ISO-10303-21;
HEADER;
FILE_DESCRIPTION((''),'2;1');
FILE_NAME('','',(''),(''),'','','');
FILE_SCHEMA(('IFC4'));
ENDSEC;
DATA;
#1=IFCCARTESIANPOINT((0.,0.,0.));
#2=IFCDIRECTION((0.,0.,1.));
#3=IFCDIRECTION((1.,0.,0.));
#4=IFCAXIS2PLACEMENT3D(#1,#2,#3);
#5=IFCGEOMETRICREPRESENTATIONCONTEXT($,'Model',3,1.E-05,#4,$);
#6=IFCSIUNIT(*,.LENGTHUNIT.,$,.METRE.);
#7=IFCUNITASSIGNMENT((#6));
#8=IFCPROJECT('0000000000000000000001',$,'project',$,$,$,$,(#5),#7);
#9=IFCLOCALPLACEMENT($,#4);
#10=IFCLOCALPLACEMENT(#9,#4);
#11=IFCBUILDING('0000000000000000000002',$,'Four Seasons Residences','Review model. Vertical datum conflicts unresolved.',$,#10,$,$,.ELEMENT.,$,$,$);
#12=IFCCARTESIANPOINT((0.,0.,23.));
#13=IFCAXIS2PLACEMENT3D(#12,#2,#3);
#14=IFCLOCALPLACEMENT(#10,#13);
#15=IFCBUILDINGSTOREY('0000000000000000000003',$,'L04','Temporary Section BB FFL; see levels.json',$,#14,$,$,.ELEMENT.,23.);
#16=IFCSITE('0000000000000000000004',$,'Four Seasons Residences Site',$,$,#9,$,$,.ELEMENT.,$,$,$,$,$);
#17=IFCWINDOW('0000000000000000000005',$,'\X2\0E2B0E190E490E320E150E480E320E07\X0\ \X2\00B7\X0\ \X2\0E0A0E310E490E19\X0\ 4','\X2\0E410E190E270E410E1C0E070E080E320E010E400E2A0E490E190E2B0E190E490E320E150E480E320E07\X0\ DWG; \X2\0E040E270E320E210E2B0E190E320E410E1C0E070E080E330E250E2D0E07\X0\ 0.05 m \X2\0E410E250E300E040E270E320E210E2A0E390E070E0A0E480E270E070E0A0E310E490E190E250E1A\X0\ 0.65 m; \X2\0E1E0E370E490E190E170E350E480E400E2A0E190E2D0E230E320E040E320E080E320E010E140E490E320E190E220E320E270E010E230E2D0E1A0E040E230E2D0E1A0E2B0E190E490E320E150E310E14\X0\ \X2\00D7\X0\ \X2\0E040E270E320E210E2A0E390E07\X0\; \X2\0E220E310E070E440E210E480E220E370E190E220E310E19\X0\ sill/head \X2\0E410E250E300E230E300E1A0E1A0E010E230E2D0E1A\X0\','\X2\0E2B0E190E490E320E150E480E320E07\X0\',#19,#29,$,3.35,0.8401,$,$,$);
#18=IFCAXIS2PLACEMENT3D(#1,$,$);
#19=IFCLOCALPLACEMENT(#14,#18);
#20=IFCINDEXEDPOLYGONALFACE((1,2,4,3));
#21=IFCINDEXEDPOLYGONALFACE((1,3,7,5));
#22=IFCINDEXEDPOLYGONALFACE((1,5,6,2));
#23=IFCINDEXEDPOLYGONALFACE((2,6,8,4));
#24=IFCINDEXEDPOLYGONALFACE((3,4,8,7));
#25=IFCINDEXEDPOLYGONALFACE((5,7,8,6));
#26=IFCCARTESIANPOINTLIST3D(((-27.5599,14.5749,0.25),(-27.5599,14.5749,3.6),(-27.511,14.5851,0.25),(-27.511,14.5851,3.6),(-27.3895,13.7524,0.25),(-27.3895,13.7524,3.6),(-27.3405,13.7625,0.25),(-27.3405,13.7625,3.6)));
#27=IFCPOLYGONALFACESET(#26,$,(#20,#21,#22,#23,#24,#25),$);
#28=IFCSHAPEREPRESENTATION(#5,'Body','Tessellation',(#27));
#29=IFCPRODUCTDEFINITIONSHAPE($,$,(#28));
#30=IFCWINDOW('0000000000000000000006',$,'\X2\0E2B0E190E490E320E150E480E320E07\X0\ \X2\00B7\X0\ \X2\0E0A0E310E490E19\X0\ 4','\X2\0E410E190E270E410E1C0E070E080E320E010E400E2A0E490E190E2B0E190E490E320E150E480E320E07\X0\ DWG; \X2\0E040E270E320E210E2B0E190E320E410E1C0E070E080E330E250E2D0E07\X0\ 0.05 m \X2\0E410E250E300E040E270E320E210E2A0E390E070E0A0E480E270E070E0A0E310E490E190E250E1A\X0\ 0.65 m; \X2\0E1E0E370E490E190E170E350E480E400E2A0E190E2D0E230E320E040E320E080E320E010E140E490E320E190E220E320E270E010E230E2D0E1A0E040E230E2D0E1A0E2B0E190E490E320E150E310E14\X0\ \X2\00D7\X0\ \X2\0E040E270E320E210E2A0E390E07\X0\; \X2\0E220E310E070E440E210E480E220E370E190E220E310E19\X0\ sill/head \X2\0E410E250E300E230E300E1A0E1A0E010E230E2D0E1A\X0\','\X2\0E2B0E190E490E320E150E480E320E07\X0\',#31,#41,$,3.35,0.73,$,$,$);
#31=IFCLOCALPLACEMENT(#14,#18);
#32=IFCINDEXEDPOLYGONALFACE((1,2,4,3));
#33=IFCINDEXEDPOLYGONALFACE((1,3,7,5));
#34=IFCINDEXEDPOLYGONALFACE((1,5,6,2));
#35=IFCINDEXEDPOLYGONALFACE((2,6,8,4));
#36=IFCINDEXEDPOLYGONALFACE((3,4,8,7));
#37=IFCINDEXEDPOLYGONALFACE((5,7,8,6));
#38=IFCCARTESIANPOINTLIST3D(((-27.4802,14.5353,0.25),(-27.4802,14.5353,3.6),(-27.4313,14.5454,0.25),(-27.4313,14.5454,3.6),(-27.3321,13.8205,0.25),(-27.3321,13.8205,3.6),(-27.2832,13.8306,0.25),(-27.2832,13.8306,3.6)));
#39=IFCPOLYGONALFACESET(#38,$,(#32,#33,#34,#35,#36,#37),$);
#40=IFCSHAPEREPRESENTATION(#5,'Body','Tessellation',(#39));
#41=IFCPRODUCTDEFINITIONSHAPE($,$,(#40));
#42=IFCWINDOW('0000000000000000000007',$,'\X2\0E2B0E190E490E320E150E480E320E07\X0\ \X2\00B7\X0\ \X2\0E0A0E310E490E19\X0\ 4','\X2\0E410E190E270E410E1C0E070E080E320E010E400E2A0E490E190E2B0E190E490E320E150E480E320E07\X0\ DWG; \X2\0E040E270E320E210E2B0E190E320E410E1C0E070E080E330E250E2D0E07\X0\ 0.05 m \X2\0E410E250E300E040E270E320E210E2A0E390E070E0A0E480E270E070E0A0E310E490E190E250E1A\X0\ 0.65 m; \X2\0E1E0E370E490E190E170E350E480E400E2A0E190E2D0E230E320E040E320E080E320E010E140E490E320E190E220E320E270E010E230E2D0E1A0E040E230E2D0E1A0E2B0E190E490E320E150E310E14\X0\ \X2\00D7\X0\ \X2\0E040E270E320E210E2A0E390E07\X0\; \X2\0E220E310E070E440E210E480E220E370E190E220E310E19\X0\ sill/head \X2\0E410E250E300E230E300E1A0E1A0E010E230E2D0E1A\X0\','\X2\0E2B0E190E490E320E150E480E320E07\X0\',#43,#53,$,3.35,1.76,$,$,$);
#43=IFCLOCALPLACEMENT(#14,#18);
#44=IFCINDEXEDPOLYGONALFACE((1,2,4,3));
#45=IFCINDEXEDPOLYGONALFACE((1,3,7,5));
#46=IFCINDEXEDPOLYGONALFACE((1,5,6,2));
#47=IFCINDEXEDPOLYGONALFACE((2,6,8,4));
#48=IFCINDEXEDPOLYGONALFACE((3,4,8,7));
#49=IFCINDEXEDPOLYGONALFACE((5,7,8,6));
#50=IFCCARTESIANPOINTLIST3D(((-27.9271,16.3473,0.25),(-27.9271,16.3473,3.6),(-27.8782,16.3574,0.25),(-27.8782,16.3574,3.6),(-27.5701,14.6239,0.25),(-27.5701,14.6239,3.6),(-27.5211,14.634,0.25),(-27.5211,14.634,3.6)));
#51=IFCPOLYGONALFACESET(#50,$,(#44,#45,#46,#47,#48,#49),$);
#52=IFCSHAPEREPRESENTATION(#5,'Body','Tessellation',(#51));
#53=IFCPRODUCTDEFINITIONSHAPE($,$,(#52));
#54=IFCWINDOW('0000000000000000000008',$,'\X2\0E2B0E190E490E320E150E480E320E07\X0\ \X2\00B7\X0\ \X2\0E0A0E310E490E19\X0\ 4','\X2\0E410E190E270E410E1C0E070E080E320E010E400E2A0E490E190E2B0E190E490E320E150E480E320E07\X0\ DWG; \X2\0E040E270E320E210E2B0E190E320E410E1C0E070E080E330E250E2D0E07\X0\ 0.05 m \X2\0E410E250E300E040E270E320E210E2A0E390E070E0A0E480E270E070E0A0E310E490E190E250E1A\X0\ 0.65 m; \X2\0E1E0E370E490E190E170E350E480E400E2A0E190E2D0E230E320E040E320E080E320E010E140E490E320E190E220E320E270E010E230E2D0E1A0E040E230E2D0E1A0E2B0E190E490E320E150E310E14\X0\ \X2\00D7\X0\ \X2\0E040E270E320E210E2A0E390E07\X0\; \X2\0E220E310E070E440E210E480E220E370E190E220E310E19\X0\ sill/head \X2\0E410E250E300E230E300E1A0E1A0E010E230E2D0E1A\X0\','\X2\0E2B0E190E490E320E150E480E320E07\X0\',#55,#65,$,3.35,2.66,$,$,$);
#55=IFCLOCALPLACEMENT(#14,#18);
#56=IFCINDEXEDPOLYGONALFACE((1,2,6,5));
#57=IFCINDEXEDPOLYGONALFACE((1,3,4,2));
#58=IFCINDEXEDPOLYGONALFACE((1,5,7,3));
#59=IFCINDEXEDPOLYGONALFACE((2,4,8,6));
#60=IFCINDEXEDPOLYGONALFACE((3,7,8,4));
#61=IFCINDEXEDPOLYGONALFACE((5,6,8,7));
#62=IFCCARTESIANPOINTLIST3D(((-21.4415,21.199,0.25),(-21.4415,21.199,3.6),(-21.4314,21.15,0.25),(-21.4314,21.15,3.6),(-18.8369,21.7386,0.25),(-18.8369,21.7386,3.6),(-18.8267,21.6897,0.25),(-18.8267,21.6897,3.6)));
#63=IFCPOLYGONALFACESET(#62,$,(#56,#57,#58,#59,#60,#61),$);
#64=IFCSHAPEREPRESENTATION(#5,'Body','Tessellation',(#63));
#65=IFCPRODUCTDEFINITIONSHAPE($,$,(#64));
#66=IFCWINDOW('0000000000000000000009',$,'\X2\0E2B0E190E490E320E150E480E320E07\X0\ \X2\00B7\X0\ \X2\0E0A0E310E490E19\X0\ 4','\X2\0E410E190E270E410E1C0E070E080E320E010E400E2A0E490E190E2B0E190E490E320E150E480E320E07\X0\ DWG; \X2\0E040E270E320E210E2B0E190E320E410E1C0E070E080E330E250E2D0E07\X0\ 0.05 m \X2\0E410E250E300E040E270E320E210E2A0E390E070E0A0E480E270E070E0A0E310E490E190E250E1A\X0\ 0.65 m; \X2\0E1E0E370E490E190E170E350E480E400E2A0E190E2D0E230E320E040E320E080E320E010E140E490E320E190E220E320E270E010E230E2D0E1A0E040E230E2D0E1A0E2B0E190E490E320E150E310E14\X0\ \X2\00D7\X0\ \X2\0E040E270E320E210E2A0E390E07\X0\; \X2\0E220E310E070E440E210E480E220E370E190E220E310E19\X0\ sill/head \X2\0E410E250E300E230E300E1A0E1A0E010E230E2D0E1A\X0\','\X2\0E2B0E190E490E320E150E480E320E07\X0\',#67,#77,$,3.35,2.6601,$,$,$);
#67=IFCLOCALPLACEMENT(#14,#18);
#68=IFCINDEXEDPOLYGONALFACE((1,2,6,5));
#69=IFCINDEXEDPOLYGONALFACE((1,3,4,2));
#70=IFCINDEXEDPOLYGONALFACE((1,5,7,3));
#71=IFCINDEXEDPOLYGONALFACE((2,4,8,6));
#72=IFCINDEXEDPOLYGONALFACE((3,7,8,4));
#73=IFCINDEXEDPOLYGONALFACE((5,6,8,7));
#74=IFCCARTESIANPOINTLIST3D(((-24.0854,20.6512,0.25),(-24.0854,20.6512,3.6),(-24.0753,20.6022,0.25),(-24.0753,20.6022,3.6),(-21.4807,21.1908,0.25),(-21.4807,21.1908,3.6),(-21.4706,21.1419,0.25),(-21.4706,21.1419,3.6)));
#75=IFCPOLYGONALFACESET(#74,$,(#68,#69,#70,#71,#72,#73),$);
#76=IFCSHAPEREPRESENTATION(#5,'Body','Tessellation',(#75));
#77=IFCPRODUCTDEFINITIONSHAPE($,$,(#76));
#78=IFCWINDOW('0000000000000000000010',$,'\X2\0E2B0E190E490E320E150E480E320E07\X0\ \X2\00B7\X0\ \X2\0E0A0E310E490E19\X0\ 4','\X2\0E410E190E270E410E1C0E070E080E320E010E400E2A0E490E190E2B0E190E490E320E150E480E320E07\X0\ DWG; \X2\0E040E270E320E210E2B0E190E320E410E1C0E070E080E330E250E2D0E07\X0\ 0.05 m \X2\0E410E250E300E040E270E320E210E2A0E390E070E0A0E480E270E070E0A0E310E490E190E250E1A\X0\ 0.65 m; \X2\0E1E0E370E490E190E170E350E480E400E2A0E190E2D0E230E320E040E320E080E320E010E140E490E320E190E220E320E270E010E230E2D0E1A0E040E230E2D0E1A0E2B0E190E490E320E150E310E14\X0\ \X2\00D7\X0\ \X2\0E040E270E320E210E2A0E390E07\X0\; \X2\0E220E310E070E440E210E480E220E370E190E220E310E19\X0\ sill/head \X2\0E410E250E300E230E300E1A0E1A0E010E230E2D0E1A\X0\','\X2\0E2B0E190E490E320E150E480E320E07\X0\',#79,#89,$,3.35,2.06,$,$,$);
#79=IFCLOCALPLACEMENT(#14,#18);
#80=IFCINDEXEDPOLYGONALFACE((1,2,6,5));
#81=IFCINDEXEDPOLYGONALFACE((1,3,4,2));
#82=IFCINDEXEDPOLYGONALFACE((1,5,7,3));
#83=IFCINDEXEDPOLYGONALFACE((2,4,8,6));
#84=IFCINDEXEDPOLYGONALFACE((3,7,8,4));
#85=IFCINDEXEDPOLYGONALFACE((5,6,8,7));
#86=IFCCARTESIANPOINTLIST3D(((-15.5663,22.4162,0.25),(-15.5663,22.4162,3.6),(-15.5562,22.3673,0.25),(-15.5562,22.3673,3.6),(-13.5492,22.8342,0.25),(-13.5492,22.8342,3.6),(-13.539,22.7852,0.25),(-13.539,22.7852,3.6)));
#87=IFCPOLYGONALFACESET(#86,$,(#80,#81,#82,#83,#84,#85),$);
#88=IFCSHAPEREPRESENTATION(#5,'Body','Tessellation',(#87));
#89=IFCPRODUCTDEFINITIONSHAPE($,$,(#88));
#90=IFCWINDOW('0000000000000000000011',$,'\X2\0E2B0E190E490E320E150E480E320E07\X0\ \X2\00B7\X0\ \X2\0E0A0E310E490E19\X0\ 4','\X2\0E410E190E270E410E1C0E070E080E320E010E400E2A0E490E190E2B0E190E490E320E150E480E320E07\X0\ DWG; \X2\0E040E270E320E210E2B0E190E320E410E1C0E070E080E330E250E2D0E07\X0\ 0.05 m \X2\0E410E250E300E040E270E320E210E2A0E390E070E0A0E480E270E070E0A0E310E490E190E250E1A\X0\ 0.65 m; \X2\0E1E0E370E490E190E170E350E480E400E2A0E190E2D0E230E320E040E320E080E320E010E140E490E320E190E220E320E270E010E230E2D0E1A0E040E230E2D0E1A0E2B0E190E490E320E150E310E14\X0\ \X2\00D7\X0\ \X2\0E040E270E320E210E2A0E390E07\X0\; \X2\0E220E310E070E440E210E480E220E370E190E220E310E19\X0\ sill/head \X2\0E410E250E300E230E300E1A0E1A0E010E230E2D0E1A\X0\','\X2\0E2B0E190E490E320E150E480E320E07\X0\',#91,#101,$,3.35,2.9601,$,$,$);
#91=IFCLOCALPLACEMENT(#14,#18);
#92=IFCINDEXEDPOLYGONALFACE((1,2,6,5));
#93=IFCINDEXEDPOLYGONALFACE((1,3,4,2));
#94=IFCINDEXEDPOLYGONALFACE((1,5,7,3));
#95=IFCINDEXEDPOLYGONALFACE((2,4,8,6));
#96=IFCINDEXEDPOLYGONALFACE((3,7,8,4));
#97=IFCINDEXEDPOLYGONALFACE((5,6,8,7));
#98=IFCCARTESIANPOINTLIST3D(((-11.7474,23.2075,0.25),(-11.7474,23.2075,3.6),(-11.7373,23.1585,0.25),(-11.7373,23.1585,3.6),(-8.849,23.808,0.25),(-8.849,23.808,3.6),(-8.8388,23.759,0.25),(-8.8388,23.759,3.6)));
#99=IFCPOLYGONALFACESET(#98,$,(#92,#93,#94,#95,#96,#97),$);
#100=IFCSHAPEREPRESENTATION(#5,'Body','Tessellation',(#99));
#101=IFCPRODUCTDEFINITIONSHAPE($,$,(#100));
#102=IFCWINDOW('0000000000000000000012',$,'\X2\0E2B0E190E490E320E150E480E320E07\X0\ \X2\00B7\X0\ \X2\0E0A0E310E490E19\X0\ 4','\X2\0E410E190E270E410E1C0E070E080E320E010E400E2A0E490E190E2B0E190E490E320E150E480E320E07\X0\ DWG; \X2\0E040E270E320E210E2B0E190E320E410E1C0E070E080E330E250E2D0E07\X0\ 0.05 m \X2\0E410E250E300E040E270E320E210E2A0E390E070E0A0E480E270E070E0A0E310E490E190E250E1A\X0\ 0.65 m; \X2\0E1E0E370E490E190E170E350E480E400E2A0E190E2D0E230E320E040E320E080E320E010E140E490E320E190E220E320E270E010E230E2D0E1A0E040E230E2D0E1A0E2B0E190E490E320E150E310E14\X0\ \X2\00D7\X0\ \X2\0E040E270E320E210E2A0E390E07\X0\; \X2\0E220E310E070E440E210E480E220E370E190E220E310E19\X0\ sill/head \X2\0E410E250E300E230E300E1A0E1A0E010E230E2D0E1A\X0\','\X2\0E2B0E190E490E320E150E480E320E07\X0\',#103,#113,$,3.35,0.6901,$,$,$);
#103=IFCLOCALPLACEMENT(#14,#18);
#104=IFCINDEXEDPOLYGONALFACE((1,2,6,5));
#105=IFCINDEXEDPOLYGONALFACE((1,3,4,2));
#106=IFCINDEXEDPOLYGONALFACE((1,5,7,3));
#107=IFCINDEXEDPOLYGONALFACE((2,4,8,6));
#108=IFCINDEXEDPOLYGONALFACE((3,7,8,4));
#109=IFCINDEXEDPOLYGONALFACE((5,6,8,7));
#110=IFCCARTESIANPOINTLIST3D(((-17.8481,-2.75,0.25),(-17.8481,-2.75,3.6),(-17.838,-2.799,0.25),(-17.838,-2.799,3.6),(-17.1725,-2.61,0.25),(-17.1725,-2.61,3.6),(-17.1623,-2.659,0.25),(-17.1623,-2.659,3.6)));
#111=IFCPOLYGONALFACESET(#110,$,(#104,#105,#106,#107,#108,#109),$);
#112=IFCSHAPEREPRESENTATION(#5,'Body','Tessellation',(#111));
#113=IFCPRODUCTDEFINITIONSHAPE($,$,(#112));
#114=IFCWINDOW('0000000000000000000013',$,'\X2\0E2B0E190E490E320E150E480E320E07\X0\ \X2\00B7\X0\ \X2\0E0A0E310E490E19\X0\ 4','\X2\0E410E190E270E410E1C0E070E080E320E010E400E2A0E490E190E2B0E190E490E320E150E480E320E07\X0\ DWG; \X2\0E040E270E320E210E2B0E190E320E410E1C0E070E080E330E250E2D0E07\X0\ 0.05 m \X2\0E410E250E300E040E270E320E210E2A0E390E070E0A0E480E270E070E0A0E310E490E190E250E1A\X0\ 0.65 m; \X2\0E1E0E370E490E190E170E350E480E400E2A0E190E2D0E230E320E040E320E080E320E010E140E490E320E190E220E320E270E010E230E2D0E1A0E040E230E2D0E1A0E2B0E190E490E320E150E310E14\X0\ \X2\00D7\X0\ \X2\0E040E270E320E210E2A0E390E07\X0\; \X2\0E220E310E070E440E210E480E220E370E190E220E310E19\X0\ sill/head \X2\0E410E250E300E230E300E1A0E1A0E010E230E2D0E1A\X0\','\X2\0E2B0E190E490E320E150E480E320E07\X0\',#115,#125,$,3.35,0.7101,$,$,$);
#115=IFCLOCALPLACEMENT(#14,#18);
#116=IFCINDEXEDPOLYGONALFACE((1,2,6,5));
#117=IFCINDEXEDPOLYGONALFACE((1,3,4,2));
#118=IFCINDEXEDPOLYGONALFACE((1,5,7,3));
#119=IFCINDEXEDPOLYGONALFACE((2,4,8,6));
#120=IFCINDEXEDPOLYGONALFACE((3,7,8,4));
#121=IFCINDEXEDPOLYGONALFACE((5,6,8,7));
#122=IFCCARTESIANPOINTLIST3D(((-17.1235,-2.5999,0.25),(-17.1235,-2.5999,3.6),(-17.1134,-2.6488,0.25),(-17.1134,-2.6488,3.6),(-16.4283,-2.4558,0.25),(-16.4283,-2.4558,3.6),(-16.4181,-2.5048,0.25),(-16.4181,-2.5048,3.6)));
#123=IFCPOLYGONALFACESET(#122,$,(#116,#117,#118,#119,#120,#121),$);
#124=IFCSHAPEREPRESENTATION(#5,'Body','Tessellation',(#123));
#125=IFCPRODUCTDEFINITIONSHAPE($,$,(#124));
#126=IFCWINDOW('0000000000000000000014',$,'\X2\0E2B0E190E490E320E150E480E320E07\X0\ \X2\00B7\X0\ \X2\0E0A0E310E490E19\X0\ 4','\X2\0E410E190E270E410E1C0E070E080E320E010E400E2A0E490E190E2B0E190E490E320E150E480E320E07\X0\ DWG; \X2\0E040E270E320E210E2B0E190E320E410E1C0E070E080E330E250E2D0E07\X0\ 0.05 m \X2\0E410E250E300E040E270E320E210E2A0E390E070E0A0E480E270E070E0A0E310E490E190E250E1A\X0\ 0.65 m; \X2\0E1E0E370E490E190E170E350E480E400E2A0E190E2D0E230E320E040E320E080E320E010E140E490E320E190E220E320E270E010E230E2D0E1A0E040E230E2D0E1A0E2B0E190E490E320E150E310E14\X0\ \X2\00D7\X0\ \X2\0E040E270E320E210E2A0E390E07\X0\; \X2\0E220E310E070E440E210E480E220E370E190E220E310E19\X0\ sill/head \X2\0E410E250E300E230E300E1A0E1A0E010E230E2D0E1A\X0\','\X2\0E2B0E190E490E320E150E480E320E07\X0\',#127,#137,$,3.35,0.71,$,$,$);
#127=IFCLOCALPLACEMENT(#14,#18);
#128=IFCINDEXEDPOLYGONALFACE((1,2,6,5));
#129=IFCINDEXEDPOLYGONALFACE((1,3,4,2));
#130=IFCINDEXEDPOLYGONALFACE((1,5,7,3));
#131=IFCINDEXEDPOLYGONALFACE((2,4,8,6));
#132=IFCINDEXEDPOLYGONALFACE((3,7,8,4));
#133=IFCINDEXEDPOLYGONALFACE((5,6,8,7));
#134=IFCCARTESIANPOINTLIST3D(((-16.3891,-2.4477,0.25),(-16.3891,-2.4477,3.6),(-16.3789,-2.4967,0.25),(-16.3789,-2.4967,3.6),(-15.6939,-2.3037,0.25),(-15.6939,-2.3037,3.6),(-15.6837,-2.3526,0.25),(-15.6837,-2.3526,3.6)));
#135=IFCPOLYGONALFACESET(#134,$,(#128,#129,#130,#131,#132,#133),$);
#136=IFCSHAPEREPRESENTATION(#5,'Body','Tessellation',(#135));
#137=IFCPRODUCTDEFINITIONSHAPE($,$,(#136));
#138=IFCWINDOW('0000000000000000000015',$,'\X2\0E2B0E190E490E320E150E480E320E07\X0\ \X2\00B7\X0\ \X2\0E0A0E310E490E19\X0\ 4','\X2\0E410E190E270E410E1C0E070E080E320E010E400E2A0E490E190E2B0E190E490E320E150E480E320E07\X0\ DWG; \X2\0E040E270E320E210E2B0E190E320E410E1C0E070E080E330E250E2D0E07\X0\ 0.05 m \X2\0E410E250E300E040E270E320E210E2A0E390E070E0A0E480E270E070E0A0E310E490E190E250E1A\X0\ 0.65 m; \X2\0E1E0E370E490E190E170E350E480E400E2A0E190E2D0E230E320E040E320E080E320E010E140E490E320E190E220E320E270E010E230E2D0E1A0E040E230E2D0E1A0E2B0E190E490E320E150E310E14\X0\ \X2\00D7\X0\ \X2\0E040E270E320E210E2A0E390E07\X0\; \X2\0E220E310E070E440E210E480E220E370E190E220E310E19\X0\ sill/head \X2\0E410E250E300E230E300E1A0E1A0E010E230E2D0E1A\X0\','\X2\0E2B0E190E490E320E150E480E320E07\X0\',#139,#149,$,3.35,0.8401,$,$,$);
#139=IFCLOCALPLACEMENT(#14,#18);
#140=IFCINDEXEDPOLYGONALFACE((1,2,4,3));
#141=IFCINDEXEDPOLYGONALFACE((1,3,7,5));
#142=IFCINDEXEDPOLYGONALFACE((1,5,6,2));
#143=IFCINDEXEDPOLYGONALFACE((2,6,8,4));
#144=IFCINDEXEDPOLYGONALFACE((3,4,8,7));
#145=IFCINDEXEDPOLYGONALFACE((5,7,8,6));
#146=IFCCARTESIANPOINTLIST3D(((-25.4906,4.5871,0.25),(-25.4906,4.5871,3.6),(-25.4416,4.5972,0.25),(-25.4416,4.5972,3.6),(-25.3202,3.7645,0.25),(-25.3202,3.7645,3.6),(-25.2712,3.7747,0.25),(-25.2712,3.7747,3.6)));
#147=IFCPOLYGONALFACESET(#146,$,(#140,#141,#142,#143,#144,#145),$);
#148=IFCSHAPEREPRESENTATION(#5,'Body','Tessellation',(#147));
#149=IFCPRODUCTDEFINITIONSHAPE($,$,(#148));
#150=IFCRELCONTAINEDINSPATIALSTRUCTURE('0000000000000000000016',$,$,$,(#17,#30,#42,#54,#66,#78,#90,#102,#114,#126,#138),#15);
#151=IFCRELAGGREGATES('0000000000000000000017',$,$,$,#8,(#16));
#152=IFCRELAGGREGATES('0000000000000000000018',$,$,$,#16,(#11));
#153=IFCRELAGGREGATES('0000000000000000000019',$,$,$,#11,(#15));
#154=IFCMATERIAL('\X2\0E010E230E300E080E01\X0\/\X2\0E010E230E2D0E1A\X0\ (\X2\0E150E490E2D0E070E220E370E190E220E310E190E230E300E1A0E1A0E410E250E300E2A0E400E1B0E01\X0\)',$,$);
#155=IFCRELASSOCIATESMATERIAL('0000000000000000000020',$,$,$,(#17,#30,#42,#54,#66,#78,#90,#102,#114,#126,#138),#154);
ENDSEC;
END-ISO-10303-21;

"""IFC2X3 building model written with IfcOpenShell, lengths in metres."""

from ifc_helpers import new_model, si_unit, frame, origin_with_axes, place, context, project, spatial, polyline, outline, extrude, material, element, save


model = new_model("IFC2X3")

# Units and contexts
model_context = context("Model", 3, precision=1e-05, world=origin_with_axes())
ifc_project = project(units=[si_unit("LENGTHUNIT", "METRE")], contexts=[model_context])

# Site, building, storey
site_placement = place(None, origin_with_axes())
site = spatial("IfcSite", under=ifc_project, at=site_placement, Name="Four Seasons Residences Site", CompositionType="ELEMENT")
building_placement = place(site_placement, origin_with_axes())
building = spatial("IfcBuilding", under=site, at=building_placement, Name="Four Seasons Residences", Description="Review model. Vertical datum conflicts unresolved.", CompositionType="ELEMENT")
storey_placement = place(building_placement, frame((0.0, 0.0, 23.0), z_axis=(0.0, 0.0, 1.0), x_axis=(1.0, 0.0, 0.0)))
storey = spatial("IfcBuildingStorey", under=building, at=storey_placement, Name="L04", Description="Temporary Section BB FFL; see levels.json", CompositionType="ELEMENT", Elevation=23.0)

# Windows
ifc_material = material(Name="กระจก/กรอบ (ต้องยืนยันระบบและสเปก)")
window_1_placement = place(storey_placement, origin_with_axes())
element("IfcWindow", 1, at=window_1_placement, inside=storey, material=ifc_material, Name="หน้าต่าง · ชั้น 4", Description="แนวแผงจากเส้นหน้าต่าง DWG; ความหนาแผงจำลอง 0.05 m และความสูงช่วงชั้นลบ 0.65 m; พื้นที่เสนอราคาจากด้านยาวกรอบครอบหน้าตัด × ความสูง; ยังไม่ยืนยัน sill/head และระบบกรอบ", ObjectType="หน้าต่าง", OverallHeight=3.35, OverallWidth=0.8401, context=model_context, shape_type="SweptSolid", body=[
    extrude(outline(polyline([(-27.3405, 13.7625), (-27.3895, 13.7524), (-27.5599, 14.5749), (-27.511, 14.5851), (-27.3405, 13.7625)])), frame((0.0, 0.0, 0.25), z_axis=(0.0, 0.0, 1.0), x_axis=(1.0, 0.0, 0.0)), (0.0, 0.0, 1.0), 3.35),
])
window_2_placement = place(storey_placement, origin_with_axes())
element("IfcWindow", 2, at=window_2_placement, inside=storey, material=ifc_material, Name="หน้าต่าง · ชั้น 4", Description="แนวแผงจากเส้นหน้าต่าง DWG; ความหนาแผงจำลอง 0.05 m และความสูงช่วงชั้นลบ 0.65 m; พื้นที่เสนอราคาจากด้านยาวกรอบครอบหน้าตัด × ความสูง; ยังไม่ยืนยัน sill/head และระบบกรอบ", ObjectType="หน้าต่าง", OverallHeight=3.35, OverallWidth=0.73, context=model_context, shape_type="SweptSolid", body=[
    extrude(outline(polyline([(-27.2832, 13.8306), (-27.3321, 13.8205), (-27.4802, 14.5353), (-27.4313, 14.5454), (-27.2832, 13.8306)])), frame((0.0, 0.0, 0.25), z_axis=(0.0, 0.0, 1.0), x_axis=(1.0, 0.0, 0.0)), (0.0, 0.0, 1.0), 3.35),
])
window_3_placement = place(storey_placement, origin_with_axes())
element("IfcWindow", 3, at=window_3_placement, inside=storey, material=ifc_material, Name="หน้าต่าง · ชั้น 4", Description="แนวแผงจากเส้นหน้าต่าง DWG; ความหนาแผงจำลอง 0.05 m และความสูงช่วงชั้นลบ 0.65 m; พื้นที่เสนอราคาจากด้านยาวกรอบครอบหน้าตัด × ความสูง; ยังไม่ยืนยัน sill/head และระบบกรอบ", ObjectType="หน้าต่าง", OverallHeight=3.35, OverallWidth=1.76, context=model_context, shape_type="SweptSolid", body=[
    extrude(outline(polyline([(-27.5211, 14.634), (-27.5701, 14.6239), (-27.9271, 16.3473), (-27.8782, 16.3574), (-27.5211, 14.634)])), frame((0.0, 0.0, 0.25), z_axis=(0.0, 0.0, 1.0), x_axis=(1.0, 0.0, 0.0)), (0.0, 0.0, 1.0), 3.35),
])
window_4_placement = place(storey_placement, origin_with_axes())
element("IfcWindow", 4, at=window_4_placement, inside=storey, material=ifc_material, Name="หน้าต่าง · ชั้น 4", Description="แนวแผงจากเส้นหน้าต่าง DWG; ความหนาแผงจำลอง 0.05 m และความสูงช่วงชั้นลบ 0.65 m; พื้นที่เสนอราคาจากด้านยาวกรอบครอบหน้าตัด × ความสูง; ยังไม่ยืนยัน sill/head และระบบกรอบ", ObjectType="หน้าต่าง", OverallHeight=3.35, OverallWidth=2.66, context=model_context, shape_type="SweptSolid", body=[
    extrude(outline(polyline([(-18.8369, 21.7386), (-18.8267, 21.6897), (-21.4314, 21.15), (-21.4415, 21.199), (-18.8369, 21.7386)])), frame((0.0, 0.0, 0.25), z_axis=(0.0, 0.0, 1.0), x_axis=(1.0, 0.0, 0.0)), (0.0, 0.0, 1.0), 3.35),
])
window_5_placement = place(storey_placement, origin_with_axes())
element("IfcWindow", 5, at=window_5_placement, inside=storey, material=ifc_material, Name="หน้าต่าง · ชั้น 4", Description="แนวแผงจากเส้นหน้าต่าง DWG; ความหนาแผงจำลอง 0.05 m และความสูงช่วงชั้นลบ 0.65 m; พื้นที่เสนอราคาจากด้านยาวกรอบครอบหน้าตัด × ความสูง; ยังไม่ยืนยัน sill/head และระบบกรอบ", ObjectType="หน้าต่าง", OverallHeight=3.35, OverallWidth=2.6601, context=model_context, shape_type="SweptSolid", body=[
    extrude(outline(polyline([(-21.4807, 21.1908), (-21.4706, 21.1419), (-24.0753, 20.6022), (-24.0854, 20.6512), (-21.4807, 21.1908)])), frame((0.0, 0.0, 0.25), z_axis=(0.0, 0.0, 1.0), x_axis=(1.0, 0.0, 0.0)), (0.0, 0.0, 1.0), 3.35),
])
window_6_placement = place(storey_placement, origin_with_axes())
element("IfcWindow", 6, at=window_6_placement, inside=storey, material=ifc_material, Name="หน้าต่าง · ชั้น 4", Description="แนวแผงจากเส้นหน้าต่าง DWG; ความหนาแผงจำลอง 0.05 m และความสูงช่วงชั้นลบ 0.65 m; พื้นที่เสนอราคาจากด้านยาวกรอบครอบหน้าตัด × ความสูง; ยังไม่ยืนยัน sill/head และระบบกรอบ", ObjectType="หน้าต่าง", OverallHeight=3.35, OverallWidth=2.06, context=model_context, shape_type="SweptSolid", body=[
    extrude(outline(polyline([(-13.5492, 22.8342), (-13.539, 22.7852), (-15.5562, 22.3673), (-15.5663, 22.4162), (-13.5492, 22.8342)])), frame((0.0, 0.0, 0.25), z_axis=(0.0, 0.0, 1.0), x_axis=(1.0, 0.0, 0.0)), (0.0, 0.0, 1.0), 3.35),
])
window_7_placement = place(storey_placement, origin_with_axes())
element("IfcWindow", 7, at=window_7_placement, inside=storey, material=ifc_material, Name="หน้าต่าง · ชั้น 4", Description="แนวแผงจากเส้นหน้าต่าง DWG; ความหนาแผงจำลอง 0.05 m และความสูงช่วงชั้นลบ 0.65 m; พื้นที่เสนอราคาจากด้านยาวกรอบครอบหน้าตัด × ความสูง; ยังไม่ยืนยัน sill/head และระบบกรอบ", ObjectType="หน้าต่าง", OverallHeight=3.35, OverallWidth=2.9601, context=model_context, shape_type="SweptSolid", body=[
    extrude(outline(polyline([(-8.849, 23.808), (-8.8388, 23.759), (-11.7373, 23.1585), (-11.7474, 23.2075), (-8.849, 23.808)])), frame((0.0, 0.0, 0.25), z_axis=(0.0, 0.0, 1.0), x_axis=(1.0, 0.0, 0.0)), (0.0, 0.0, 1.0), 3.35),
])
window_8_placement = place(storey_placement, origin_with_axes())
element("IfcWindow", 8, at=window_8_placement, inside=storey, material=ifc_material, Name="หน้าต่าง · ชั้น 4", Description="แนวแผงจากเส้นหน้าต่าง DWG; ความหนาแผงจำลอง 0.05 m และความสูงช่วงชั้นลบ 0.65 m; พื้นที่เสนอราคาจากด้านยาวกรอบครอบหน้าตัด × ความสูง; ยังไม่ยืนยัน sill/head และระบบกรอบ", ObjectType="หน้าต่าง", OverallHeight=3.35, OverallWidth=0.6901, context=model_context, shape_type="SweptSolid", body=[
    extrude(outline(polyline([(-17.1725, -2.61), (-17.1623, -2.659), (-17.838, -2.799), (-17.8481, -2.75), (-17.1725, -2.61)])), frame((0.0, 0.0, 0.25), z_axis=(0.0, 0.0, 1.0), x_axis=(1.0, 0.0, 0.0)), (0.0, 0.0, 1.0), 3.35),
])
window_9_placement = place(storey_placement, origin_with_axes())
element("IfcWindow", 9, at=window_9_placement, inside=storey, material=ifc_material, Name="หน้าต่าง · ชั้น 4", Description="แนวแผงจากเส้นหน้าต่าง DWG; ความหนาแผงจำลอง 0.05 m และความสูงช่วงชั้นลบ 0.65 m; พื้นที่เสนอราคาจากด้านยาวกรอบครอบหน้าตัด × ความสูง; ยังไม่ยืนยัน sill/head และระบบกรอบ", ObjectType="หน้าต่าง", OverallHeight=3.35, OverallWidth=0.7101, context=model_context, shape_type="SweptSolid", body=[
    extrude(outline(polyline([(-16.4283, -2.4558), (-16.4181, -2.5048), (-17.1134, -2.6488), (-17.1235, -2.5999), (-16.4283, -2.4558)])), frame((0.0, 0.0, 0.25), z_axis=(0.0, 0.0, 1.0), x_axis=(1.0, 0.0, 0.0)), (0.0, 0.0, 1.0), 3.35),
])
window_10_placement = place(storey_placement, origin_with_axes())
element("IfcWindow", 10, at=window_10_placement, inside=storey, material=ifc_material, Name="หน้าต่าง · ชั้น 4", Description="แนวแผงจากเส้นหน้าต่าง DWG; ความหนาแผงจำลอง 0.05 m และความสูงช่วงชั้นลบ 0.65 m; พื้นที่เสนอราคาจากด้านยาวกรอบครอบหน้าตัด × ความสูง; ยังไม่ยืนยัน sill/head และระบบกรอบ", ObjectType="หน้าต่าง", OverallHeight=3.35, OverallWidth=0.71, context=model_context, shape_type="SweptSolid", body=[
    extrude(outline(polyline([(-15.6939, -2.3037), (-15.6837, -2.3526), (-16.3789, -2.4967), (-16.3891, -2.4477), (-15.6939, -2.3037)])), frame((0.0, 0.0, 0.25), z_axis=(0.0, 0.0, 1.0), x_axis=(1.0, 0.0, 0.0)), (0.0, 0.0, 1.0), 3.35),
])
window_11_placement = place(storey_placement, origin_with_axes())
element("IfcWindow", 11, at=window_11_placement, inside=storey, material=ifc_material, Name="หน้าต่าง · ชั้น 4", Description="แนวแผงจากเส้นหน้าต่าง DWG; ความหนาแผงจำลอง 0.05 m และความสูงช่วงชั้นลบ 0.65 m; พื้นที่เสนอราคาจากด้านยาวกรอบครอบหน้าตัด × ความสูง; ยังไม่ยืนยัน sill/head และระบบกรอบ", ObjectType="หน้าต่าง", OverallHeight=3.35, OverallWidth=0.8401, context=model_context, shape_type="SweptSolid", body=[
    extrude(outline(polyline([(-25.2712, 3.7747), (-25.3202, 3.7645), (-25.4906, 4.5871), (-25.4416, 4.5972), (-25.2712, 3.7747)])), frame((0.0, 0.0, 0.25), z_axis=(0.0, 0.0, 1.0), x_axis=(1.0, 0.0, 0.0)), (0.0, 0.0, 1.0), 3.35),
])

save(model, "model.ifc")
